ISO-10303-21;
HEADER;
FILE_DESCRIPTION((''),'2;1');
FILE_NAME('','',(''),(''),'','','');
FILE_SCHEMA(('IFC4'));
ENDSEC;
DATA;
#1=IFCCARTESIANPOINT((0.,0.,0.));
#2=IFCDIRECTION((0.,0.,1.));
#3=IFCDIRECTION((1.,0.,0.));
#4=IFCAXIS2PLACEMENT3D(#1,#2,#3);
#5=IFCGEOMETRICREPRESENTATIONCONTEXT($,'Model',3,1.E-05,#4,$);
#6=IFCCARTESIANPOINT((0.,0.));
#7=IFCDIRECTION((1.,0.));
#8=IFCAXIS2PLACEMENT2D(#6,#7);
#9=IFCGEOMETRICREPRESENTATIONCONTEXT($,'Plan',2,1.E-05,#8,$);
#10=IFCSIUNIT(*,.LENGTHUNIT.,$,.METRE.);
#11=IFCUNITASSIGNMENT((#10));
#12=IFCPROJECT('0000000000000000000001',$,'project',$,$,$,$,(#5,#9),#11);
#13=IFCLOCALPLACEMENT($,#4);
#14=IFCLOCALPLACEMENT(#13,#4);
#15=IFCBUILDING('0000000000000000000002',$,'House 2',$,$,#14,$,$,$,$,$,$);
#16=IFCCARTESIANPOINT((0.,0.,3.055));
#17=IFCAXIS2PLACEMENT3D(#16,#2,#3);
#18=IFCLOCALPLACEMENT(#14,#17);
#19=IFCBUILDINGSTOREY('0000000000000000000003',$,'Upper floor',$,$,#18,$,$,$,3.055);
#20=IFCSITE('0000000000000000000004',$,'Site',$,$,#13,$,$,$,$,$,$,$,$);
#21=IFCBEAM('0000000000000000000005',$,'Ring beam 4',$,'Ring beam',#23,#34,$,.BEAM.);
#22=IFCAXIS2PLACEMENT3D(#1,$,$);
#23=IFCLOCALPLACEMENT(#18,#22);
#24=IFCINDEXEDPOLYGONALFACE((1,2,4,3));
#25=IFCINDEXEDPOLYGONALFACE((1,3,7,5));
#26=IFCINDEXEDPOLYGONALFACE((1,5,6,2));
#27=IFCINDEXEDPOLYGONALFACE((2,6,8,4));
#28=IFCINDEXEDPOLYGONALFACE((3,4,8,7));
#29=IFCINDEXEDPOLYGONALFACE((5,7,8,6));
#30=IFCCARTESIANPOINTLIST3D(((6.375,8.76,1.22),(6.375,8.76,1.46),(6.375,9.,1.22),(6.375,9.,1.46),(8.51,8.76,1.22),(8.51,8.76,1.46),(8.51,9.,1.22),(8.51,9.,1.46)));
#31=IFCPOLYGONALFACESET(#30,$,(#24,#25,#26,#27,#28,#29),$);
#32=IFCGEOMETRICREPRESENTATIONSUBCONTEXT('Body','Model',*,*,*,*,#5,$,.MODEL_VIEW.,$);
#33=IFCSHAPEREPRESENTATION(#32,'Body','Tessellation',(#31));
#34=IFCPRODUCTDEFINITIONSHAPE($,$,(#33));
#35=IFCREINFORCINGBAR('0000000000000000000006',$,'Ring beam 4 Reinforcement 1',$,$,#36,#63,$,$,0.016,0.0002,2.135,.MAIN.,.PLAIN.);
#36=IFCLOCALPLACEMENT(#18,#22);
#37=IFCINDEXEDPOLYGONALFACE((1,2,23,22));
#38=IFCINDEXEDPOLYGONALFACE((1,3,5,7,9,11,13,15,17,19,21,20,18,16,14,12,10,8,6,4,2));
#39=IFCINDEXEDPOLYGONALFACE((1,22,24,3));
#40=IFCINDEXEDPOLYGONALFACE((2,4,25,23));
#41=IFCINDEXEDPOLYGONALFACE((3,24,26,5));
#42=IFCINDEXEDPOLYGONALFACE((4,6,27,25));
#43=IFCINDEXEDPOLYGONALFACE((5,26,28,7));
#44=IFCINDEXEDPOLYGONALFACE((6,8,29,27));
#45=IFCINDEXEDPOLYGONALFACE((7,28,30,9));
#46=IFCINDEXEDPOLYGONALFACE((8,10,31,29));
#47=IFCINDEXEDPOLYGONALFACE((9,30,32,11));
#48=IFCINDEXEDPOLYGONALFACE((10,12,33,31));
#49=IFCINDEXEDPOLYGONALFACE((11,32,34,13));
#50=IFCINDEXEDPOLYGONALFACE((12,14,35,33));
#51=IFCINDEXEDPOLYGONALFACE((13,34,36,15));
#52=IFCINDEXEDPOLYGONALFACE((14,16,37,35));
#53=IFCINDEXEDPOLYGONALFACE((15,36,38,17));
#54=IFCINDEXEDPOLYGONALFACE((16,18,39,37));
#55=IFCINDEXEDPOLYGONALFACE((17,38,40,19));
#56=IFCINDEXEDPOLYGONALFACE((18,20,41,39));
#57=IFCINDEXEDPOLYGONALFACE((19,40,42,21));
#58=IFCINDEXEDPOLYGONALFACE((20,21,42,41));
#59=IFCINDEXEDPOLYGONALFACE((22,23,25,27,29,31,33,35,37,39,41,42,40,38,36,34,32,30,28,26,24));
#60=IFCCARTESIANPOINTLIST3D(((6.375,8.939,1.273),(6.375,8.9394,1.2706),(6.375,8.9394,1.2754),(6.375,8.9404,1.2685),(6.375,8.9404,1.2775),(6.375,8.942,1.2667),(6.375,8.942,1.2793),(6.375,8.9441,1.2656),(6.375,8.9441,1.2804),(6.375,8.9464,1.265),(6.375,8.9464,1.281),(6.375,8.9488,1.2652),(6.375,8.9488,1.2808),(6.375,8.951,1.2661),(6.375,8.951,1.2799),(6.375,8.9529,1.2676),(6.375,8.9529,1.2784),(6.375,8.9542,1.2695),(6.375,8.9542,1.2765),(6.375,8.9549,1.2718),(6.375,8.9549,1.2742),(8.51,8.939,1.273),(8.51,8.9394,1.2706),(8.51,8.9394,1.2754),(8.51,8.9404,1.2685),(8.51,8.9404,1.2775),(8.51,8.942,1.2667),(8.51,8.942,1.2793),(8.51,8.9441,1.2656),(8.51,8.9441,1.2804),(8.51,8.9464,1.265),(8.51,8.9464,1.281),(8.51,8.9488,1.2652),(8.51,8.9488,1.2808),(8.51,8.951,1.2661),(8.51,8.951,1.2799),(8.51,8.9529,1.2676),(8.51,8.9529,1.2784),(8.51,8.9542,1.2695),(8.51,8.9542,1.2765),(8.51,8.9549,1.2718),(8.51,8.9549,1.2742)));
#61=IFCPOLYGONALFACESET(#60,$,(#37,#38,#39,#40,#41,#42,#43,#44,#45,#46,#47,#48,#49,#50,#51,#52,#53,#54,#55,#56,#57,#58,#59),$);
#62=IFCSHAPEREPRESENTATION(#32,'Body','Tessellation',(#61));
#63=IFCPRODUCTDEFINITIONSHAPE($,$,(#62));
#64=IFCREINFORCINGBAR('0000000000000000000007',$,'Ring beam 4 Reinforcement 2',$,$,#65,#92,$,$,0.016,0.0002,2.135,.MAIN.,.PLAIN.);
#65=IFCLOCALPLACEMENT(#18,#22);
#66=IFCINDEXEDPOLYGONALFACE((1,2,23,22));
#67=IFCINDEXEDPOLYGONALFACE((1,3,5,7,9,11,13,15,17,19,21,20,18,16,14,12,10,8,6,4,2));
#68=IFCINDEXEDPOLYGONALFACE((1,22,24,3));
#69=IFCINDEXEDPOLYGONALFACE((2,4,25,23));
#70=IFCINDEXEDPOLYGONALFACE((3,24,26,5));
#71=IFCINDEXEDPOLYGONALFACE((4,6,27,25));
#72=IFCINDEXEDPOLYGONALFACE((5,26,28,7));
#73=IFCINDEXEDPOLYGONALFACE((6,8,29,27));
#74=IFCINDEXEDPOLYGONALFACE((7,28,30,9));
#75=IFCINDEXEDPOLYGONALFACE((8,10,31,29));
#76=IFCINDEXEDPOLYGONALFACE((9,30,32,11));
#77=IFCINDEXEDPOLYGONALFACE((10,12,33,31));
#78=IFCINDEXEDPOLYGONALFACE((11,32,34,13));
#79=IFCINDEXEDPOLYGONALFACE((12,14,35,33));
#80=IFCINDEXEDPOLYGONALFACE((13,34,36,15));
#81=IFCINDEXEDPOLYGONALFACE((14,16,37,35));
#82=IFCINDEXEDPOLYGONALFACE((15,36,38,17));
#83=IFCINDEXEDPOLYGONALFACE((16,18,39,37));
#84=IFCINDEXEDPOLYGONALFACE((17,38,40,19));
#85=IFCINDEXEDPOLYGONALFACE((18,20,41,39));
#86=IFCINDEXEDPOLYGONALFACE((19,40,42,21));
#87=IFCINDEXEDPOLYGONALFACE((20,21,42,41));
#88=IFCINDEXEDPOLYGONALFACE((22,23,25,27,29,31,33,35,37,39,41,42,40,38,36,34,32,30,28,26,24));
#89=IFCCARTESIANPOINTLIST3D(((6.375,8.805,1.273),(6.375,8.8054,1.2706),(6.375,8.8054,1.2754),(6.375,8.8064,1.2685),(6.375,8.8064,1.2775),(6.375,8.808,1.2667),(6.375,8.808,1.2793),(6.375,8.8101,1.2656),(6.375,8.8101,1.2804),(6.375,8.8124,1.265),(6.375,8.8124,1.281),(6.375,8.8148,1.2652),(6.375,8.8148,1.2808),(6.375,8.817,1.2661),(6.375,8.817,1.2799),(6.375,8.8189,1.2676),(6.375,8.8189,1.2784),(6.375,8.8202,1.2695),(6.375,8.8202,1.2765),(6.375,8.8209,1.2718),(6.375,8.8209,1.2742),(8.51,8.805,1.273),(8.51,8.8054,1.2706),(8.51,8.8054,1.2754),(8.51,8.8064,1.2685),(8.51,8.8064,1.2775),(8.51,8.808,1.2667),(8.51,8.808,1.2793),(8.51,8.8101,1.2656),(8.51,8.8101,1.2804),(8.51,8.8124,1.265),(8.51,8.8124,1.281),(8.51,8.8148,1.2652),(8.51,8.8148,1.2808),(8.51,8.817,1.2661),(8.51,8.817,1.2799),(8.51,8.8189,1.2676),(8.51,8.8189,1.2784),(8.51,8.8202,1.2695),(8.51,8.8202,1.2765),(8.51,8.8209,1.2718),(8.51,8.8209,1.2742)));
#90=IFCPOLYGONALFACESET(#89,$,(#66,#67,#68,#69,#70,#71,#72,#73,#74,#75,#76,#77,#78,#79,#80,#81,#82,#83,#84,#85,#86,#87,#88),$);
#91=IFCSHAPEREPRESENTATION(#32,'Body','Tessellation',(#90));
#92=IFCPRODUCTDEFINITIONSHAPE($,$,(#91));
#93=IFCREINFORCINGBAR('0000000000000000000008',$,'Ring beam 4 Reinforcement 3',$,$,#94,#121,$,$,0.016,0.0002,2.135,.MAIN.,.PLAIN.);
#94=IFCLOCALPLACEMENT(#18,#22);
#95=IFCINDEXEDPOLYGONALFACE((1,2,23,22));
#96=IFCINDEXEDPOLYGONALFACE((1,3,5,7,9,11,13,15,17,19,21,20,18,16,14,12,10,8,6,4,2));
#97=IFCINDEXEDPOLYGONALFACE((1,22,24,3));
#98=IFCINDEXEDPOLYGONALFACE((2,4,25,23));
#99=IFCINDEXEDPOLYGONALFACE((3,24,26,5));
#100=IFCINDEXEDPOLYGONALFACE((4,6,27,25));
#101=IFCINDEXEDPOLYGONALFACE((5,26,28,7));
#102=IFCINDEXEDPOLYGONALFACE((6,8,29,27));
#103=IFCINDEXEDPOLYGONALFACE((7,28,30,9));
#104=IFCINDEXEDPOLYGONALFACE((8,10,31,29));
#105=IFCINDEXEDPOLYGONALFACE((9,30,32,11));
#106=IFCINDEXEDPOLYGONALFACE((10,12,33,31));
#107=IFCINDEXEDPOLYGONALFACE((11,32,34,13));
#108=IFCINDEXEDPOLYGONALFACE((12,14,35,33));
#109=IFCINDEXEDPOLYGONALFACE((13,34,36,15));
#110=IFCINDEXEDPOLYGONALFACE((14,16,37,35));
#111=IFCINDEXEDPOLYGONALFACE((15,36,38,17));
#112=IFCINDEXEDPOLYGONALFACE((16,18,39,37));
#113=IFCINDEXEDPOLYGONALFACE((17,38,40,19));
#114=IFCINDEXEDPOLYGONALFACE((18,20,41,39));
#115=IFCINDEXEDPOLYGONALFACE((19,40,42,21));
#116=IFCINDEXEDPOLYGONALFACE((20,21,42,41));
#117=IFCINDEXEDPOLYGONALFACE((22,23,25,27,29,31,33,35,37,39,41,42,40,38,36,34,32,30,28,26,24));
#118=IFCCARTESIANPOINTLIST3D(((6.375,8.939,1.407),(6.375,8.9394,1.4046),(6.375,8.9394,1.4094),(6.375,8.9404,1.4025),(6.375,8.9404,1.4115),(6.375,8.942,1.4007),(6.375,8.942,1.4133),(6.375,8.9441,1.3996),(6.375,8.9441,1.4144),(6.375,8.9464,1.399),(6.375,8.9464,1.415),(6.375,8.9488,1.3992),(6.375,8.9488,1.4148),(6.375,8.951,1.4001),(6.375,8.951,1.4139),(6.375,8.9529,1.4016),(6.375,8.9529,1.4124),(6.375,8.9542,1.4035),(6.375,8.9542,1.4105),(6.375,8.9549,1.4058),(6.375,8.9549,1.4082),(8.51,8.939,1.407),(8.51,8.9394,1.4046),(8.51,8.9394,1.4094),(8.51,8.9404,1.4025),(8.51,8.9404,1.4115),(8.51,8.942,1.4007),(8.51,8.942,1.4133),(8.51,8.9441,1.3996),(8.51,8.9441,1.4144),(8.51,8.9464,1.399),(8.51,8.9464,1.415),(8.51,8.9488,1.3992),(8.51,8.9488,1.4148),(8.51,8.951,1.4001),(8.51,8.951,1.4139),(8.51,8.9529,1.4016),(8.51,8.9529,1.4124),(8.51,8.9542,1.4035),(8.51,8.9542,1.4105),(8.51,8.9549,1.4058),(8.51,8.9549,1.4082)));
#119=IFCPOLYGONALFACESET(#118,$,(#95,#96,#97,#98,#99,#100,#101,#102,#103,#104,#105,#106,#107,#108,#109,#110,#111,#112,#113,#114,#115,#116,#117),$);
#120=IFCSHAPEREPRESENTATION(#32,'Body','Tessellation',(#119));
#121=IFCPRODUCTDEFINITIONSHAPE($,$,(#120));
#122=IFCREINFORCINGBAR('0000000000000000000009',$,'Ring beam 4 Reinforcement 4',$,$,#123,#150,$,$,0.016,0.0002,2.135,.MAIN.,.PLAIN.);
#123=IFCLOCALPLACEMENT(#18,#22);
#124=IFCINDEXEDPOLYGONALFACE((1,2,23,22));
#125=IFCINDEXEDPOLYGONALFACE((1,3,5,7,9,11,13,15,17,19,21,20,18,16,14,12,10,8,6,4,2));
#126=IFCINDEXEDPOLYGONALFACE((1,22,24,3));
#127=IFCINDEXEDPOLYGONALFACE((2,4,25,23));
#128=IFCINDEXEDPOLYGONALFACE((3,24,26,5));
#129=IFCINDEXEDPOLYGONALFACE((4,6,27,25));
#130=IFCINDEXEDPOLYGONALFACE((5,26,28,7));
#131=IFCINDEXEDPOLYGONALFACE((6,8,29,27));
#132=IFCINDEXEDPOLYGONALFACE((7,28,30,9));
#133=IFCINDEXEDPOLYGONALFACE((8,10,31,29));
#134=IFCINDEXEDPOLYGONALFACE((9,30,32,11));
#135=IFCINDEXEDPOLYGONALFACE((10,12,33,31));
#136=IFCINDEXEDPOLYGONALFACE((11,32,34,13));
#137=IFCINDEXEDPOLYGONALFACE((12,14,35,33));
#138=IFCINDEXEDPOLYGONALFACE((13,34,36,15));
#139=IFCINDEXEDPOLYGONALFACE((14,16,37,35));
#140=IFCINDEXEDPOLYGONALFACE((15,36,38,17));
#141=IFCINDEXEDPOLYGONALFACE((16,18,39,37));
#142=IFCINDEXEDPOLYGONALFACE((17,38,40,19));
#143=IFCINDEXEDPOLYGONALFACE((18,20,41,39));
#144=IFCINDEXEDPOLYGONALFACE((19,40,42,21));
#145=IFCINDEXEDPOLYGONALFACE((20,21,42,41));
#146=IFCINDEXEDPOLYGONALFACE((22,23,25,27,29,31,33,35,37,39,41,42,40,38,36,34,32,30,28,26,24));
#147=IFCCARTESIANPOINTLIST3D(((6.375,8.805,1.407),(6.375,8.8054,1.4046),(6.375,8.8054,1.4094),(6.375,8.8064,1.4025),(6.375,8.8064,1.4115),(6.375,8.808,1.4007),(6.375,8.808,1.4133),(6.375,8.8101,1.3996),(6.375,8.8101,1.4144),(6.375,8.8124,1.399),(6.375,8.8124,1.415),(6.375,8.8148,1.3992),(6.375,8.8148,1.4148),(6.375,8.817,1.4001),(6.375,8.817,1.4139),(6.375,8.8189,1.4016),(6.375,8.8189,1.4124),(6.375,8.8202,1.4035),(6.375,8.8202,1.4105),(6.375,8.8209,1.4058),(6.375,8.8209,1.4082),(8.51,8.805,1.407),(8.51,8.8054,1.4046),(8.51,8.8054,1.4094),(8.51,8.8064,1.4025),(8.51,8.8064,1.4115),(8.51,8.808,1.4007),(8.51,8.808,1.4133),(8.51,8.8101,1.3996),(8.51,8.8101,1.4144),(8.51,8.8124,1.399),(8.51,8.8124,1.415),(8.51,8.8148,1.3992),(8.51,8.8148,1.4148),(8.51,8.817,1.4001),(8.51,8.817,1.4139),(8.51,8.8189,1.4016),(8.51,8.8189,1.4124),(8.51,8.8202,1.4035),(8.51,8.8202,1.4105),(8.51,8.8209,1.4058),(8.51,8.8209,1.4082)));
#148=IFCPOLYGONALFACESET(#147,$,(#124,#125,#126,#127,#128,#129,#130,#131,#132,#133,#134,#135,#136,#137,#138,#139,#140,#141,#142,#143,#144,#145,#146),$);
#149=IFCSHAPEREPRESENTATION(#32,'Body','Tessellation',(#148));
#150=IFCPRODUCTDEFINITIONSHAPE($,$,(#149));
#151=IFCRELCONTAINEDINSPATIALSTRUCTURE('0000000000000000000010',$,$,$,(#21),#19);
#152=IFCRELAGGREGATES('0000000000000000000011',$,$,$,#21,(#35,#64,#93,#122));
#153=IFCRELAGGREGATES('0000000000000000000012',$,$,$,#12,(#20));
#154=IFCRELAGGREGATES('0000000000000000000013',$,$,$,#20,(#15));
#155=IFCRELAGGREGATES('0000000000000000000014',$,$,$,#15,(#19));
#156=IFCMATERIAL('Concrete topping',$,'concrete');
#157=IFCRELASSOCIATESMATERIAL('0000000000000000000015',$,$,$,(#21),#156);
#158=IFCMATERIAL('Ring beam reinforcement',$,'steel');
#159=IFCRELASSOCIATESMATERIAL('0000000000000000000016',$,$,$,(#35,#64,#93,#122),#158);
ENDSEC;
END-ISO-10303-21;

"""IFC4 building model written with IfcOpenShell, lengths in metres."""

from ifc_helpers import new_model, si_unit, frame, origin_with_axes, origin_2d, origin_2d_with_axis, place, context, subcontext, project, spatial, circle_curve, rectangle, outline, extrude, material, element, aggregate, save


model = new_model("IFC4")

# Units and contexts
model_context = context("Model", 3, precision=1e-05, world=origin_with_axes())
plan_context = context("Plan", 2, precision=1e-05, world=origin_2d_with_axis())
body_context_1 = subcontext(model_context, "Body", "Model", "MODEL_VIEW")
ifc_project = project(units=[si_unit("LENGTHUNIT", "METRE")], contexts=[model_context, plan_context])

# Site, building, storey
site_placement = place(None, origin_with_axes())
site = spatial("IfcSite", under=ifc_project, at=site_placement, Name="Site")
building_placement = place(site_placement, origin_with_axes())
building = spatial("IfcBuilding", under=site, at=building_placement, Name="House 2")
storey_placement = place(building_placement, frame((0.0, 0.0, 3.055), z_axis=(0.0, 0.0, 1.0), x_axis=(1.0, 0.0, 0.0)))
storey = spatial("IfcBuildingStorey", under=building, at=storey_placement, Name="Upper floor", Elevation=3.055)

# Beam
ifc_material_1 = material(Name="Concrete topping", Category="concrete")
beam_1_placement = place(storey_placement, frame((8.51, 8.88, 1.34), z_axis=(0.0, 0.0, 1.0), x_axis=(-1.0, 0.0, 0.0)))
beam_1 = element("IfcBeam", 1, at=beam_1_placement, inside=storey, material=ifc_material_1, Name="Ring beam 4", ObjectType="Ring beam", PredefinedType="BEAM", context=body_context_1, shape_type="SweptSolid", body=[
    extrude(rectangle(XDim=0.24, YDim=0.24), frame((0.0, 0.0, 0.0), z_axis=(1.0, 0.0, 0.0), x_axis=(0.0, 1.0, 0.0)), (0.0, 0.0, 1.0), 2.135),
])

# Reinforcing bars
ifc_material_2 = material(Name="Ring beam reinforcement", Category="steel")
reinforcing_bar_1_placement = place(beam_1_placement, frame((0.0, -0.067, -0.067), z_axis=(0.0, 0.0, 1.0), x_axis=(1.0, 0.0, 0.0)))
reinforcing_bar_1 = element("IfcReinforcingBar", 2, at=reinforcing_bar_1_placement, material=ifc_material_2, Name="Ring beam 4 Reinforcement 1", BarLength=2.135, BarSurface="PLAIN", CrossSectionArea=0.0002, NominalDiameter=0.016, PredefinedType="MAIN", context=body_context_1, shape_type="SweptSolid", body=[
    extrude(outline(circle_curve(origin_2d(), 0.008)), frame((0.0, 0.0, 0.0), z_axis=(1.0, 0.0, 0.0), x_axis=(0.0, 1.0, 0.0)), (0.0, 0.0, 1.0), 2.135),
])
reinforcing_bar_2_placement = place(beam_1_placement, frame((0.0, 0.067, -0.067), z_axis=(0.0, 0.0, 1.0), x_axis=(1.0, 0.0, 0.0)))
reinforcing_bar_2 = element("IfcReinforcingBar", 3, at=reinforcing_bar_2_placement, material=ifc_material_2, Name="Ring beam 4 Reinforcement 2", BarLength=2.135, BarSurface="PLAIN", CrossSectionArea=0.0002, NominalDiameter=0.016, PredefinedType="MAIN", context=body_context_1, shape_type="SweptSolid", body=[
    extrude(outline(circle_curve(origin_2d(), 0.008)), frame((0.0, 0.0, 0.0), z_axis=(1.0, 0.0, 0.0), x_axis=(0.0, 1.0, 0.0)), (0.0, 0.0, 1.0), 2.135),
])
reinforcing_bar_3_placement = place(beam_1_placement, frame((0.0, -0.067, 0.067), z_axis=(0.0, 0.0, 1.0), x_axis=(1.0, 0.0, 0.0)))
reinforcing_bar_3 = element("IfcReinforcingBar", 4, at=reinforcing_bar_3_placement, material=ifc_material_2, Name="Ring beam 4 Reinforcement 3", BarLength=2.135, BarSurface="PLAIN", CrossSectionArea=0.0002, NominalDiameter=0.016, PredefinedType="MAIN", context=body_context_1, shape_type="SweptSolid", body=[
    extrude(outline(circle_curve(origin_2d(), 0.008)), frame((0.0, 0.0, 0.0), z_axis=(1.0, 0.0, 0.0), x_axis=(0.0, 1.0, 0.0)), (0.0, 0.0, 1.0), 2.135),
])
reinforcing_bar_4_placement = place(beam_1_placement, frame((0.0, 0.067, 0.067), z_axis=(0.0, 0.0, 1.0), x_axis=(1.0, 0.0, 0.0)))
reinforcing_bar_4 = element("IfcReinforcingBar", 5, at=reinforcing_bar_4_placement, material=ifc_material_2, Name="Ring beam 4 Reinforcement 4", BarLength=2.135, BarSurface="PLAIN", CrossSectionArea=0.0002, NominalDiameter=0.016, PredefinedType="MAIN", context=body_context_1, shape_type="SweptSolid", body=[
    extrude(outline(circle_curve(origin_2d(), 0.008)), frame((0.0, 0.0, 0.0), z_axis=(1.0, 0.0, 0.0), x_axis=(0.0, 1.0, 0.0)), (0.0, 0.0, 1.0), 2.135),
])
aggregate(beam_1, [reinforcing_bar_1, reinforcing_bar_2, reinforcing_bar_3, reinforcing_bar_4])

save(model, "model.ifc")
